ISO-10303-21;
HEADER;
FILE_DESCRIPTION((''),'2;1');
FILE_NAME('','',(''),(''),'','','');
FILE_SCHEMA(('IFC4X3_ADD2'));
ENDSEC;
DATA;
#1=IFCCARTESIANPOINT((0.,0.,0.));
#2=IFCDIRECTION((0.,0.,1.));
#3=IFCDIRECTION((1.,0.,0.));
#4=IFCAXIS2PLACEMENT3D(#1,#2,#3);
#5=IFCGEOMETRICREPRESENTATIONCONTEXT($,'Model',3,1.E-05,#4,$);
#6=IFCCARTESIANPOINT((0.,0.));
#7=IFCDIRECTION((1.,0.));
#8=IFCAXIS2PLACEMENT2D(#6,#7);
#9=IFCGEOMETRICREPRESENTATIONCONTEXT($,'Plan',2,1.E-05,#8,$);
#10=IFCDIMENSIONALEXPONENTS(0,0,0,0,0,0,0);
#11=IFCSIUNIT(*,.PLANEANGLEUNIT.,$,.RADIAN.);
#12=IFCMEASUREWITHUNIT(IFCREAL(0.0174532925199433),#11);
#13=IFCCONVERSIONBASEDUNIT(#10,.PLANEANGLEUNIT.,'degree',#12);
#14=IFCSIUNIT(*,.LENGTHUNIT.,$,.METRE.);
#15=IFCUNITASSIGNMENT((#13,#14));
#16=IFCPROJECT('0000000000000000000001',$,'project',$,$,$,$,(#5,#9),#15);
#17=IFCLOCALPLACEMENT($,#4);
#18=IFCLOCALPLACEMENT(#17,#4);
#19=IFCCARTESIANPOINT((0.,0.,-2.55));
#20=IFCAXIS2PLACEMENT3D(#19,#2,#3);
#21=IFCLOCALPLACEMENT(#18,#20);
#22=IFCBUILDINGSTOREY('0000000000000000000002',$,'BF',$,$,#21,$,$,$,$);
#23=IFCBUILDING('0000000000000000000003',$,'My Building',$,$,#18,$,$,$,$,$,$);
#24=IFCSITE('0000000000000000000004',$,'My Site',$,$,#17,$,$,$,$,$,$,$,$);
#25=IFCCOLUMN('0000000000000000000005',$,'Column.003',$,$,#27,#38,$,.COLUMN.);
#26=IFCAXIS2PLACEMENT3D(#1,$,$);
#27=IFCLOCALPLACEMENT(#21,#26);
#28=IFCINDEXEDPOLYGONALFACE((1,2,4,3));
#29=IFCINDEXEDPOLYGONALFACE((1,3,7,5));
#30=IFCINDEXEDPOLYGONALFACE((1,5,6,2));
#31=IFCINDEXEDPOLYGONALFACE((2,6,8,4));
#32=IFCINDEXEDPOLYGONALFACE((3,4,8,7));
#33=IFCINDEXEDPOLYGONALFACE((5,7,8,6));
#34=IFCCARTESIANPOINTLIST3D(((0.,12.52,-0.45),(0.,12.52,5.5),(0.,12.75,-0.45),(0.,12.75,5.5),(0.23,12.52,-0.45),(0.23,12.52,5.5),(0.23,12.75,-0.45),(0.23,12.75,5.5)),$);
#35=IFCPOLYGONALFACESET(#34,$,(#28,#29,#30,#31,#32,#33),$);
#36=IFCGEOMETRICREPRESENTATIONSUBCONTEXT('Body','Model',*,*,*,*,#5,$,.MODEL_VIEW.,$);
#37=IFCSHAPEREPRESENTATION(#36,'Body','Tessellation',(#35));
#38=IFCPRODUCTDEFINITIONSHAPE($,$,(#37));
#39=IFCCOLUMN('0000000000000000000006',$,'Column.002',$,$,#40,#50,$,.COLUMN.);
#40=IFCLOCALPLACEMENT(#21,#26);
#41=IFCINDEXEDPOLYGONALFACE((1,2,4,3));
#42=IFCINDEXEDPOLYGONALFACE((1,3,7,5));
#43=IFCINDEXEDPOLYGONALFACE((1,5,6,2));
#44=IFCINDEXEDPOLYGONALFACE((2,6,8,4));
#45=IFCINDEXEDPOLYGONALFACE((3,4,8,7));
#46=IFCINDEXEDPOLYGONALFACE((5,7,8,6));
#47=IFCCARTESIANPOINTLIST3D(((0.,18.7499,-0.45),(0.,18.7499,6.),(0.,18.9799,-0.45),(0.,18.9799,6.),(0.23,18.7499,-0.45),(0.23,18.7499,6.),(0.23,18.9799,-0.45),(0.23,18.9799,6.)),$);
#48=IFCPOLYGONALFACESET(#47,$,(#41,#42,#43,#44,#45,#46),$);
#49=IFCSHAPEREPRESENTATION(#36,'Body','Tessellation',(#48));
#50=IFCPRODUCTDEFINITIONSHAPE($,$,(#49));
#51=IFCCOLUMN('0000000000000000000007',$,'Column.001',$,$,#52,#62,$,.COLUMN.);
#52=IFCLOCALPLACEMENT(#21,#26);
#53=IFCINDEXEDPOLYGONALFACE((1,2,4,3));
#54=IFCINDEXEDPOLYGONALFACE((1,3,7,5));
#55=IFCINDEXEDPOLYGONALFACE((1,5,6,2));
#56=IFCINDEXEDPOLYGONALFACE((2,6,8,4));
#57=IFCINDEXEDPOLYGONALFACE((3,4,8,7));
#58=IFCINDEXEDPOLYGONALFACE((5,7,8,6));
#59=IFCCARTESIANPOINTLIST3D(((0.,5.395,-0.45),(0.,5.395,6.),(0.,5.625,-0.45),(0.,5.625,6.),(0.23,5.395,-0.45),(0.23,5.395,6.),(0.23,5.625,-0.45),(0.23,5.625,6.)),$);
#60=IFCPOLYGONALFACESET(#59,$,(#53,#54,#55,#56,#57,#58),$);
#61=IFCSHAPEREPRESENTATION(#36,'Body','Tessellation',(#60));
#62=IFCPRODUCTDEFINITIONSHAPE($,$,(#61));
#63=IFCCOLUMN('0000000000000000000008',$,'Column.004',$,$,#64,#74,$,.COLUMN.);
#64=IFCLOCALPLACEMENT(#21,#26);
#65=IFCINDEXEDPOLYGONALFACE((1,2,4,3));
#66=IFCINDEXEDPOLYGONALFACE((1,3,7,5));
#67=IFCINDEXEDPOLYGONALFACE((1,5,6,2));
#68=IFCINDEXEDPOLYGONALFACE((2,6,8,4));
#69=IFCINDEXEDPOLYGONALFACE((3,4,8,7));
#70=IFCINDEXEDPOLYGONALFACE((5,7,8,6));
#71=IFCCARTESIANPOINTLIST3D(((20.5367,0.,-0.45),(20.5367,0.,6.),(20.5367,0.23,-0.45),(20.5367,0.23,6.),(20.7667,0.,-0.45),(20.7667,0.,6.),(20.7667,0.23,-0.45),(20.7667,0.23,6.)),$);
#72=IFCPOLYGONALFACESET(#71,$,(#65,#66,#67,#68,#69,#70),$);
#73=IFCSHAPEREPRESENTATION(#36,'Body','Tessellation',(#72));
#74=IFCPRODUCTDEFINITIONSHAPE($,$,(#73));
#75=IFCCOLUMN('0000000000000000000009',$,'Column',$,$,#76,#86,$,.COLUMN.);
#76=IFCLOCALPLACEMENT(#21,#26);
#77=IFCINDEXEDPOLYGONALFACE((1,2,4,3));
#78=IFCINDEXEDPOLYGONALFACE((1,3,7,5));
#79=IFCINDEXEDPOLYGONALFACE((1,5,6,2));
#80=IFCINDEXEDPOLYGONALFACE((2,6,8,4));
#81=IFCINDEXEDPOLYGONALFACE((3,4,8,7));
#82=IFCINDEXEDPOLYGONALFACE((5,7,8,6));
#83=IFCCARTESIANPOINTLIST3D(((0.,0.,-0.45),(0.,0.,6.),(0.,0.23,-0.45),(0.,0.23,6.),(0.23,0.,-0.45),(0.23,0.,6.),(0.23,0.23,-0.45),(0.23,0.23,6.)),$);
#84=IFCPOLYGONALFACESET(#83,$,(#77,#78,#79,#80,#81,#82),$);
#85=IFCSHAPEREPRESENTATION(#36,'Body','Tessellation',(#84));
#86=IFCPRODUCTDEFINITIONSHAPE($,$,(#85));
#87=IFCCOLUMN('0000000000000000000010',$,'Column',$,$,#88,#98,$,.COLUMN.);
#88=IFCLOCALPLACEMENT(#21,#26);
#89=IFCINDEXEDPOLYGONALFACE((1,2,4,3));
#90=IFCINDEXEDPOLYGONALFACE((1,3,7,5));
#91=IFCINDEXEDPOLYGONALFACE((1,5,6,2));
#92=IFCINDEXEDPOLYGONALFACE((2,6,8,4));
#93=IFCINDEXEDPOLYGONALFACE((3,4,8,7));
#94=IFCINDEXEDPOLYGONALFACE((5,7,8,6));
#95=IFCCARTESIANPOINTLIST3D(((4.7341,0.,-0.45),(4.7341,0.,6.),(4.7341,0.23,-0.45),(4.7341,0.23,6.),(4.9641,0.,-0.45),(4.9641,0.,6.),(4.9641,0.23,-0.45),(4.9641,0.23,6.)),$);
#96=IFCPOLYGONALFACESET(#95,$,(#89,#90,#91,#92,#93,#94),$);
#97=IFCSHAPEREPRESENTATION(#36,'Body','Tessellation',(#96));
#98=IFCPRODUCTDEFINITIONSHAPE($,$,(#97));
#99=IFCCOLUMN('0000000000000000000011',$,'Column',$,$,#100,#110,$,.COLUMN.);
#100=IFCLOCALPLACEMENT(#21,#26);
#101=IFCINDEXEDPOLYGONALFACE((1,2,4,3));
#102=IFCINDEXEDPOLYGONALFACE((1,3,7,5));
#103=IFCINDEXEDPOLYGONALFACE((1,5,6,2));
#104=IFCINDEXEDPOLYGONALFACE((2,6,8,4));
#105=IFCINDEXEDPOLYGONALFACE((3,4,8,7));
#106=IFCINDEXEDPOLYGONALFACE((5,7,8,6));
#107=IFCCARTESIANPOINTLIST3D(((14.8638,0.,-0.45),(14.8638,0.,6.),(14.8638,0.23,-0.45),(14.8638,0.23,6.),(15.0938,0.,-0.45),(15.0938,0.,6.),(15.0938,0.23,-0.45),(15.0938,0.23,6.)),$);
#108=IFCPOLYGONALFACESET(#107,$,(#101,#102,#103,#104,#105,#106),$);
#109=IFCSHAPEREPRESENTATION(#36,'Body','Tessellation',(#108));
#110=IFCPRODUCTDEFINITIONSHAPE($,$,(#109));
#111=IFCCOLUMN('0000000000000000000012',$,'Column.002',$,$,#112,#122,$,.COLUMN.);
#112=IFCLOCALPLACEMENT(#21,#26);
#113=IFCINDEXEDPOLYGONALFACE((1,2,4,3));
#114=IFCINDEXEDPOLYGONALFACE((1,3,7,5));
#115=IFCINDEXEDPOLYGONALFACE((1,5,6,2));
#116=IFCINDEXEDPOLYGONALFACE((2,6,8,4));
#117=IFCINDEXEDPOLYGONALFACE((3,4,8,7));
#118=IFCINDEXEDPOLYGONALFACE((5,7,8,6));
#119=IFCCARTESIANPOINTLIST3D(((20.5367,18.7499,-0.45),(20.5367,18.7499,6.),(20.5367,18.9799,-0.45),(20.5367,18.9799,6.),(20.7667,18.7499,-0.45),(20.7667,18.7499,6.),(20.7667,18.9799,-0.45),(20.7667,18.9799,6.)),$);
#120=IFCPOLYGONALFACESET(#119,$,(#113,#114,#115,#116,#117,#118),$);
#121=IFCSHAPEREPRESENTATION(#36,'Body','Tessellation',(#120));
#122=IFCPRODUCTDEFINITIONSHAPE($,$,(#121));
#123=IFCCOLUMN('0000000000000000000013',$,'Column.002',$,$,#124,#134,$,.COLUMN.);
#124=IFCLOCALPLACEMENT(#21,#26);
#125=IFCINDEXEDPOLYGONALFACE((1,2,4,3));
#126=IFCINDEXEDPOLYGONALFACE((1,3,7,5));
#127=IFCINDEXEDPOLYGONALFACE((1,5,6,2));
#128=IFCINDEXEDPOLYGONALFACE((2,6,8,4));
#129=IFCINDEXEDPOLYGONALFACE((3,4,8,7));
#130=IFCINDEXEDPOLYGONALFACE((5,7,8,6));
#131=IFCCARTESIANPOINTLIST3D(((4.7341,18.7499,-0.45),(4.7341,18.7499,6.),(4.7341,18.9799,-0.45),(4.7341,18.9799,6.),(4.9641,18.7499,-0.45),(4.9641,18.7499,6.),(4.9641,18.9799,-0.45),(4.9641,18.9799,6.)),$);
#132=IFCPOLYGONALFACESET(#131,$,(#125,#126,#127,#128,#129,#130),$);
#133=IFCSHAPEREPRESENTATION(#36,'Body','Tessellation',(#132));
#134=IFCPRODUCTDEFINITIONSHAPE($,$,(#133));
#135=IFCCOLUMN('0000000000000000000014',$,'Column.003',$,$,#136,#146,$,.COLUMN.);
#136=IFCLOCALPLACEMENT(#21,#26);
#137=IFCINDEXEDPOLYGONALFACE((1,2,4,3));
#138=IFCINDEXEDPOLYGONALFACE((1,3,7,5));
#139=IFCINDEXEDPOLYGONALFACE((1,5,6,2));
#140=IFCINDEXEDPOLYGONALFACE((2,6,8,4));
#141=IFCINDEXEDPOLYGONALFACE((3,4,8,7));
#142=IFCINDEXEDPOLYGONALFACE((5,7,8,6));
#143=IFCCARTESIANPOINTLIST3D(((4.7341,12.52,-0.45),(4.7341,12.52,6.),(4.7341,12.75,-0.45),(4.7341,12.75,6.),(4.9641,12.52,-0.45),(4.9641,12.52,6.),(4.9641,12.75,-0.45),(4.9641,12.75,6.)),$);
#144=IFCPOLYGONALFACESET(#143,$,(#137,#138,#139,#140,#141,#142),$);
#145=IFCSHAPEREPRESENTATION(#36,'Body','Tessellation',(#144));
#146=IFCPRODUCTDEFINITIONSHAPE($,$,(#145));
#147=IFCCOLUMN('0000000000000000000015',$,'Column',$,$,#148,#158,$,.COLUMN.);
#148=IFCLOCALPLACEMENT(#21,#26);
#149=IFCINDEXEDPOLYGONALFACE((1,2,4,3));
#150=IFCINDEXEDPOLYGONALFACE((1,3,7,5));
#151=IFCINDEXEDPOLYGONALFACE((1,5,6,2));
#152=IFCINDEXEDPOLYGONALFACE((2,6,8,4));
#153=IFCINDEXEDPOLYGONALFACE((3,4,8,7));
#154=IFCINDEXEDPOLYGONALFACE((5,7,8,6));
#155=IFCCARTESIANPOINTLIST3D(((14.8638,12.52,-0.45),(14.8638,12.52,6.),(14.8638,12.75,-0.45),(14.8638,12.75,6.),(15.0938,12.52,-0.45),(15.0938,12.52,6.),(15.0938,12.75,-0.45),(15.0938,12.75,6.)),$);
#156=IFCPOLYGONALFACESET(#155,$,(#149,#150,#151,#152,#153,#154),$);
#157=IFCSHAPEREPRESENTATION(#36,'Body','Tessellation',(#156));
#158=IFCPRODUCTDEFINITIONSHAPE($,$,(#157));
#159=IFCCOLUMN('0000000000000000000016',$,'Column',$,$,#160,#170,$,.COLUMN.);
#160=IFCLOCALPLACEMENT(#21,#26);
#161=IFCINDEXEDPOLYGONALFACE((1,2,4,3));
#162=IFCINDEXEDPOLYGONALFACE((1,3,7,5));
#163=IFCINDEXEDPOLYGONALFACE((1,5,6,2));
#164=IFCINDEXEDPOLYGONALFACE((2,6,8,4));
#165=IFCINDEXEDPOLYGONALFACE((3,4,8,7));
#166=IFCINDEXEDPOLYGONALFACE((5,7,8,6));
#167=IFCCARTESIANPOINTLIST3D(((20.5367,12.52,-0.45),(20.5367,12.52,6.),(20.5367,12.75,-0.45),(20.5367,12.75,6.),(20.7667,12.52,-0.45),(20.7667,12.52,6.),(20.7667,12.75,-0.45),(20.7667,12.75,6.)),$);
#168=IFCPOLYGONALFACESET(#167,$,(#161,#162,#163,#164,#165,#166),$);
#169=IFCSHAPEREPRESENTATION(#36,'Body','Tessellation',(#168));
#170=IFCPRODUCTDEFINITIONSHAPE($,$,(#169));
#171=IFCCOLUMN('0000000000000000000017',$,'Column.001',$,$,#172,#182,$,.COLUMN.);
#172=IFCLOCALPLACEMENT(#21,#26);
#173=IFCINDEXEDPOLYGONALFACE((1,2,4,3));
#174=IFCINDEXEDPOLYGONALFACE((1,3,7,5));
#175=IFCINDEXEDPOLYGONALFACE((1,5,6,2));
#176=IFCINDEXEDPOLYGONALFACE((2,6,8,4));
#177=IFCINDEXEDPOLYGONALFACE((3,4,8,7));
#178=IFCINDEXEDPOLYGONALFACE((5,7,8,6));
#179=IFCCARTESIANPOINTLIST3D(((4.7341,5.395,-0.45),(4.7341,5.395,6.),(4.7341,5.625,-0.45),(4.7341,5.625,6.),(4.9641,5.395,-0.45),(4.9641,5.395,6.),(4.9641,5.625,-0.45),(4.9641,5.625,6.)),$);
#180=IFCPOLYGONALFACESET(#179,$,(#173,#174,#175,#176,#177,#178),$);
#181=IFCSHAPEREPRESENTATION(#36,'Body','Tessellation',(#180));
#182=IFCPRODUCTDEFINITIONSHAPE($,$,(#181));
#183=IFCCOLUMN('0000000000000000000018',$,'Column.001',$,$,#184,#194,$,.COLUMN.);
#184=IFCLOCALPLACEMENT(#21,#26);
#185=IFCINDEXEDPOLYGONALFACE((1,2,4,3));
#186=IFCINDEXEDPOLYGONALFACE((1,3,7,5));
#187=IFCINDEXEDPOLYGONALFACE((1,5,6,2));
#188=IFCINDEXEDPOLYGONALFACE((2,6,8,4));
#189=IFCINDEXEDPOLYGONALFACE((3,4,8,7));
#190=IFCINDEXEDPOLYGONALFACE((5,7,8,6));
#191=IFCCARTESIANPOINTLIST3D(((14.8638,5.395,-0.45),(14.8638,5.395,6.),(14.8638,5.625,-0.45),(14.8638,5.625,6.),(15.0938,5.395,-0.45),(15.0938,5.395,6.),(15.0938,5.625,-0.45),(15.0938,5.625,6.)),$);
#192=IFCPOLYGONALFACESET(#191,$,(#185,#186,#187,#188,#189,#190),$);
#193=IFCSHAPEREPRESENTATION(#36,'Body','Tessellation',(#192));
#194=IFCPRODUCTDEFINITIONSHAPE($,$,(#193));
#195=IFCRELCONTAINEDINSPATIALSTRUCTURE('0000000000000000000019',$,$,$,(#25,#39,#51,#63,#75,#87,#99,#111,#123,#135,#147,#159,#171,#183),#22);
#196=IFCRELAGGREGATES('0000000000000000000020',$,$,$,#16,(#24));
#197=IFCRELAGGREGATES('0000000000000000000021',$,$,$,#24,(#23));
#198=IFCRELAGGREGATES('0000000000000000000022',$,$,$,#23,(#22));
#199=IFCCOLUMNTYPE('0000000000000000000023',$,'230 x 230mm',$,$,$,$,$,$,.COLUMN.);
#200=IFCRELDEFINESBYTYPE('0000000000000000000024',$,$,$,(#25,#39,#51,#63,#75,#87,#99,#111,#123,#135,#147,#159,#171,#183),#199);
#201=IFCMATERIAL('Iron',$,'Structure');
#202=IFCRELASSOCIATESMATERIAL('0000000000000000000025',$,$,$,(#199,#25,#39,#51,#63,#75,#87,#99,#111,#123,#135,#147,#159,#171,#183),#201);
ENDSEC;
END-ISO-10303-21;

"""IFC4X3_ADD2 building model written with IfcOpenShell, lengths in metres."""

from ifc_helpers import new_model, entity, si_unit, converted_unit, frame, origin_with_axes, origin_2d_with_axis, place, context, subcontext, project, spatial, rectangle, extrude, material, material_profile, profile_set, profile_usage, type_object, element, save


model = new_model("IFC4X3_ADD2")

# Units and contexts
model_context = context("Model", 3, precision=1e-05, world=origin_with_axes())
plan_context = context("Plan", 2, precision=1e-05, world=origin_2d_with_axis())
body_context_1 = subcontext(model_context, "Body", "Model", "MODEL_VIEW")
ifc_project = project(units=[converted_unit("PLANEANGLEUNIT", "degree", entity("IfcReal", 0.0174532925199433), si_unit("PLANEANGLEUNIT", "RADIAN"), dimensions=[0, 0, 0, 0, 0, 0, 0]), si_unit("LENGTHUNIT", "METRE")], contexts=[model_context, plan_context])

# Site, building, storey
site_placement = place(None, origin_with_axes())
site = spatial("IfcSite", under=ifc_project, at=site_placement, Name="My Site")
building_placement = place(site_placement, origin_with_axes())
building = spatial("IfcBuilding", under=site, at=building_placement, Name="My Building")
storey_placement = place(building_placement, frame((0.0, 0.0, -2.55), z_axis=(0.0, 0.0, 1.0), x_axis=(1.0, 0.0, 0.0)))
storey = spatial("IfcBuildingStorey", under=building, at=storey_placement, Name="BF")

# Columns
ifc_material_1 = material(Name="Iron", Category="Structure")
ifc_material_profile = material_profile(ifc_material_1, rectangle(XDim=0.23, YDim=0.23))
ifc_profile_set = profile_set([ifc_material_profile])
ifc_profile_usage_1 = profile_usage(ifc_profile_set)
column_type = type_object("IfcColumnType", Name="230 x 230mm", PredefinedType="COLUMN", material=ifc_profile_set)
column_1_placement = place(storey_placement, frame((0.115, 12.635, -0.45), z_axis=(0.0, 0.0, 1.0), x_axis=(1.0, 0.0, 0.0)))
element("IfcColumn", 1, at=column_1_placement, inside=storey, type_object=column_type, material=ifc_profile_usage_1, Name="Column.003", PredefinedType="COLUMN", context=body_context_1, shape_type="SweptSolid", body=[
    extrude(rectangle(XDim=0.23, YDim=0.23), origin_with_axes(), (0.0, 0.0, 1.0), 5.95),
])
ifc_profile_usage_2 = profile_usage(ifc_profile_set)
column_2_placement = place(storey_placement, frame((0.115, 18.8649, -0.45), z_axis=(0.0, 0.0, 1.0), x_axis=(1.0, 0.0, 0.0)))
element("IfcColumn", 2, at=column_2_placement, inside=storey, type_object=column_type, material=ifc_profile_usage_2, Name="Column.002", PredefinedType="COLUMN", context=body_context_1, shape_type="SweptSolid", body=[
    extrude(rectangle(XDim=0.23, YDim=0.23), origin_with_axes(), (0.0, 0.0, 1.0), 6.45),
])
ifc_profile_usage_3 = profile_usage(ifc_profile_set)
column_3_placement = place(storey_placement, frame((0.115, 5.51, -0.45), z_axis=(0.0, 0.0, 1.0), x_axis=(1.0, 0.0, 0.0)))
element("IfcColumn", 3, at=column_3_placement, inside=storey, type_object=column_type, material=ifc_profile_usage_3, Name="Column.001", PredefinedType="COLUMN", context=body_context_1, shape_type="SweptSolid", body=[
    extrude(rectangle(XDim=0.23, YDim=0.23), origin_with_axes(), (0.0, 0.0, 1.0), 6.45),
])
ifc_profile_usage_4 = profile_usage(ifc_profile_set)
column_4_placement = place(storey_placement, frame((20.6517, 0.115, -0.45), z_axis=(0.0, 0.0, 1.0), x_axis=(1.0, 0.0, 0.0)))
element("IfcColumn", 4, at=column_4_placement, inside=storey, type_object=column_type, material=ifc_profile_usage_4, Name="Column.004", PredefinedType="COLUMN", context=body_context_1, shape_type="SweptSolid", body=[
    extrude(rectangle(XDim=0.23, YDim=0.23), origin_with_axes(), (0.0, 0.0, 1.0), 6.45),
])
ifc_profile_usage_5 = profile_usage(ifc_profile_set)
column_5_placement = place(storey_placement, frame((0.115, 0.115, -0.45), z_axis=(0.0, 0.0, 1.0), x_axis=(1.0, 0.0, 0.0)))
element("IfcColumn", 5, at=column_5_placement, inside=storey, type_object=column_type, material=ifc_profile_usage_5, Name="Column", PredefinedType="COLUMN", context=body_context_1, shape_type="SweptSolid", body=[
    extrude(rectangle(XDim=0.23, YDim=0.23), origin_with_axes(), (0.0, 0.0, 1.0), 6.45),
])
ifc_profile_usage_6 = profile_usage(ifc_profile_set)
column_6_placement = place(storey_placement, frame((4.8491, 0.115, -0.45), z_axis=(0.0, 0.0, 1.0), x_axis=(1.0, 0.0, 0.0)))
element("IfcColumn", 6, at=column_6_placement, inside=storey, type_object=column_type, material=ifc_profile_usage_6, Name="Column", PredefinedType="COLUMN", context=body_context_1, shape_type="SweptSolid", body=[
    extrude(rectangle(XDim=0.23, YDim=0.23), origin_with_axes(), (0.0, 0.0, 1.0), 6.45),
])
ifc_profile_usage_7 = profile_usage(ifc_profile_set)
column_7_placement = place(storey_placement, frame((14.9788, 0.115, -0.45), z_axis=(0.0, 0.0, 1.0), x_axis=(1.0, 0.0, 0.0)))
element("IfcColumn", 7, at=column_7_placement, inside=storey, type_object=column_type, material=ifc_profile_usage_7, Name="Column", PredefinedType="COLUMN", context=body_context_1, shape_type="SweptSolid", body=[
    extrude(rectangle(XDim=0.23, YDim=0.23), origin_with_axes(), (0.0, 0.0, 1.0), 6.45),
])
ifc_profile_usage_8 = profile_usage(ifc_profile_set)
column_8_placement = place(storey_placement, frame((20.6517, 18.8649, -0.45), z_axis=(0.0, 0.0, 1.0), x_axis=(1.0, 0.0, 0.0)))
element("IfcColumn", 8, at=column_8_placement, inside=storey, type_object=column_type, material=ifc_profile_usage_8, Name="Column.002", PredefinedType="COLUMN", context=body_context_1, shape_type="SweptSolid", body=[
    extrude(rectangle(XDim=0.23, YDim=0.23), origin_with_axes(), (0.0, 0.0, 1.0), 6.45),
])
ifc_profile_usage_9 = profile_usage(ifc_profile_set)
column_9_placement = place(storey_placement, frame((4.8491, 18.8649, -0.45), z_axis=(0.0, 0.0, 1.0), x_axis=(1.0, 0.0, 0.0)))
element("IfcColumn", 9, at=column_9_placement, inside=storey, type_object=column_type, material=ifc_profile_usage_9, Name="Column.002", PredefinedType="COLUMN", context=body_context_1, shape_type="SweptSolid", body=[
    extrude(rectangle(XDim=0.23, YDim=0.23), origin_with_axes(), (0.0, 0.0, 1.0), 6.45),
])
ifc_profile_usage_10 = profile_usage(ifc_profile_set)
column_10_placement = place(storey_placement, frame((4.8491, 12.635, -0.45), z_axis=(0.0, 0.0, 1.0), x_axis=(1.0, 0.0, 0.0)))
element("IfcColumn", 10, at=column_10_placement, inside=storey, type_object=column_type, material=ifc_profile_usage_10, Name="Column.003", PredefinedType="COLUMN", context=body_context_1, shape_type="SweptSolid", body=[
    extrude(rectangle(XDim=0.23, YDim=0.23), origin_with_axes(), (0.0, 0.0, 1.0), 6.45),
])
ifc_profile_usage_11 = profile_usage(ifc_profile_set)
column_11_placement = place(storey_placement, frame((14.9788, 12.635, -0.45), z_axis=(0.0, 0.0, 1.0), x_axis=(1.0, 0.0, 0.0)))
element("IfcColumn", 11, at=column_11_placement, inside=storey, type_object=column_type, material=ifc_profile_usage_11, Name="Column", PredefinedType="COLUMN", context=body_context_1, shape_type="SweptSolid", body=[
    extrude(rectangle(XDim=0.23, YDim=0.23), origin_with_axes(), (0.0, 0.0, 1.0), 6.45),
])
ifc_profile_usage_12 = profile_usage(ifc_profile_set)
column_12_placement = place(storey_placement, frame((20.6517, 12.635, -0.45), z_axis=(0.0, 0.0, 1.0), x_axis=(1.0, 0.0, 0.0)))
element("IfcColumn", 12, at=column_12_placement, inside=storey, type_object=column_type, material=ifc_profile_usage_12, Name="Column", PredefinedType="COLUMN", context=body_context_1, shape_type="SweptSolid", body=[
    extrude(rectangle(XDim=0.23, YDim=0.23), origin_with_axes(), (0.0, 0.0, 1.0), 6.45),
])
ifc_profile_usage_13 = profile_usage(ifc_profile_set)
column_13_placement = place(storey_placement, frame((4.8491, 5.51, -0.45), z_axis=(0.0, 0.0, 1.0), x_axis=(1.0, 0.0, 0.0)))
element("IfcColumn", 13, at=column_13_placement, inside=storey, type_object=column_type, material=ifc_profile_usage_13, Name="Column.001", PredefinedType="COLUMN", context=body_context_1, shape_type="SweptSolid", body=[
    extrude(rectangle(XDim=0.23, YDim=0.23), origin_with_axes(), (0.0, 0.0, 1.0), 6.45),
])
ifc_profile_usage_14 = profile_usage(ifc_profile_set)
column_14_placement = place(storey_placement, frame((14.9788, 5.51, -0.45), z_axis=(0.0, 0.0, 1.0), x_axis=(1.0, 0.0, 0.0)))
element("IfcColumn", 14, at=column_14_placement, inside=storey, type_object=column_type, material=ifc_profile_usage_14, Name="Column.001", PredefinedType="COLUMN", context=body_context_1, shape_type="SweptSolid", body=[
    extrude(rectangle(XDim=0.23, YDim=0.23), origin_with_axes(), (0.0, 0.0, 1.0), 6.45),
])

save(model, "model.ifc")
